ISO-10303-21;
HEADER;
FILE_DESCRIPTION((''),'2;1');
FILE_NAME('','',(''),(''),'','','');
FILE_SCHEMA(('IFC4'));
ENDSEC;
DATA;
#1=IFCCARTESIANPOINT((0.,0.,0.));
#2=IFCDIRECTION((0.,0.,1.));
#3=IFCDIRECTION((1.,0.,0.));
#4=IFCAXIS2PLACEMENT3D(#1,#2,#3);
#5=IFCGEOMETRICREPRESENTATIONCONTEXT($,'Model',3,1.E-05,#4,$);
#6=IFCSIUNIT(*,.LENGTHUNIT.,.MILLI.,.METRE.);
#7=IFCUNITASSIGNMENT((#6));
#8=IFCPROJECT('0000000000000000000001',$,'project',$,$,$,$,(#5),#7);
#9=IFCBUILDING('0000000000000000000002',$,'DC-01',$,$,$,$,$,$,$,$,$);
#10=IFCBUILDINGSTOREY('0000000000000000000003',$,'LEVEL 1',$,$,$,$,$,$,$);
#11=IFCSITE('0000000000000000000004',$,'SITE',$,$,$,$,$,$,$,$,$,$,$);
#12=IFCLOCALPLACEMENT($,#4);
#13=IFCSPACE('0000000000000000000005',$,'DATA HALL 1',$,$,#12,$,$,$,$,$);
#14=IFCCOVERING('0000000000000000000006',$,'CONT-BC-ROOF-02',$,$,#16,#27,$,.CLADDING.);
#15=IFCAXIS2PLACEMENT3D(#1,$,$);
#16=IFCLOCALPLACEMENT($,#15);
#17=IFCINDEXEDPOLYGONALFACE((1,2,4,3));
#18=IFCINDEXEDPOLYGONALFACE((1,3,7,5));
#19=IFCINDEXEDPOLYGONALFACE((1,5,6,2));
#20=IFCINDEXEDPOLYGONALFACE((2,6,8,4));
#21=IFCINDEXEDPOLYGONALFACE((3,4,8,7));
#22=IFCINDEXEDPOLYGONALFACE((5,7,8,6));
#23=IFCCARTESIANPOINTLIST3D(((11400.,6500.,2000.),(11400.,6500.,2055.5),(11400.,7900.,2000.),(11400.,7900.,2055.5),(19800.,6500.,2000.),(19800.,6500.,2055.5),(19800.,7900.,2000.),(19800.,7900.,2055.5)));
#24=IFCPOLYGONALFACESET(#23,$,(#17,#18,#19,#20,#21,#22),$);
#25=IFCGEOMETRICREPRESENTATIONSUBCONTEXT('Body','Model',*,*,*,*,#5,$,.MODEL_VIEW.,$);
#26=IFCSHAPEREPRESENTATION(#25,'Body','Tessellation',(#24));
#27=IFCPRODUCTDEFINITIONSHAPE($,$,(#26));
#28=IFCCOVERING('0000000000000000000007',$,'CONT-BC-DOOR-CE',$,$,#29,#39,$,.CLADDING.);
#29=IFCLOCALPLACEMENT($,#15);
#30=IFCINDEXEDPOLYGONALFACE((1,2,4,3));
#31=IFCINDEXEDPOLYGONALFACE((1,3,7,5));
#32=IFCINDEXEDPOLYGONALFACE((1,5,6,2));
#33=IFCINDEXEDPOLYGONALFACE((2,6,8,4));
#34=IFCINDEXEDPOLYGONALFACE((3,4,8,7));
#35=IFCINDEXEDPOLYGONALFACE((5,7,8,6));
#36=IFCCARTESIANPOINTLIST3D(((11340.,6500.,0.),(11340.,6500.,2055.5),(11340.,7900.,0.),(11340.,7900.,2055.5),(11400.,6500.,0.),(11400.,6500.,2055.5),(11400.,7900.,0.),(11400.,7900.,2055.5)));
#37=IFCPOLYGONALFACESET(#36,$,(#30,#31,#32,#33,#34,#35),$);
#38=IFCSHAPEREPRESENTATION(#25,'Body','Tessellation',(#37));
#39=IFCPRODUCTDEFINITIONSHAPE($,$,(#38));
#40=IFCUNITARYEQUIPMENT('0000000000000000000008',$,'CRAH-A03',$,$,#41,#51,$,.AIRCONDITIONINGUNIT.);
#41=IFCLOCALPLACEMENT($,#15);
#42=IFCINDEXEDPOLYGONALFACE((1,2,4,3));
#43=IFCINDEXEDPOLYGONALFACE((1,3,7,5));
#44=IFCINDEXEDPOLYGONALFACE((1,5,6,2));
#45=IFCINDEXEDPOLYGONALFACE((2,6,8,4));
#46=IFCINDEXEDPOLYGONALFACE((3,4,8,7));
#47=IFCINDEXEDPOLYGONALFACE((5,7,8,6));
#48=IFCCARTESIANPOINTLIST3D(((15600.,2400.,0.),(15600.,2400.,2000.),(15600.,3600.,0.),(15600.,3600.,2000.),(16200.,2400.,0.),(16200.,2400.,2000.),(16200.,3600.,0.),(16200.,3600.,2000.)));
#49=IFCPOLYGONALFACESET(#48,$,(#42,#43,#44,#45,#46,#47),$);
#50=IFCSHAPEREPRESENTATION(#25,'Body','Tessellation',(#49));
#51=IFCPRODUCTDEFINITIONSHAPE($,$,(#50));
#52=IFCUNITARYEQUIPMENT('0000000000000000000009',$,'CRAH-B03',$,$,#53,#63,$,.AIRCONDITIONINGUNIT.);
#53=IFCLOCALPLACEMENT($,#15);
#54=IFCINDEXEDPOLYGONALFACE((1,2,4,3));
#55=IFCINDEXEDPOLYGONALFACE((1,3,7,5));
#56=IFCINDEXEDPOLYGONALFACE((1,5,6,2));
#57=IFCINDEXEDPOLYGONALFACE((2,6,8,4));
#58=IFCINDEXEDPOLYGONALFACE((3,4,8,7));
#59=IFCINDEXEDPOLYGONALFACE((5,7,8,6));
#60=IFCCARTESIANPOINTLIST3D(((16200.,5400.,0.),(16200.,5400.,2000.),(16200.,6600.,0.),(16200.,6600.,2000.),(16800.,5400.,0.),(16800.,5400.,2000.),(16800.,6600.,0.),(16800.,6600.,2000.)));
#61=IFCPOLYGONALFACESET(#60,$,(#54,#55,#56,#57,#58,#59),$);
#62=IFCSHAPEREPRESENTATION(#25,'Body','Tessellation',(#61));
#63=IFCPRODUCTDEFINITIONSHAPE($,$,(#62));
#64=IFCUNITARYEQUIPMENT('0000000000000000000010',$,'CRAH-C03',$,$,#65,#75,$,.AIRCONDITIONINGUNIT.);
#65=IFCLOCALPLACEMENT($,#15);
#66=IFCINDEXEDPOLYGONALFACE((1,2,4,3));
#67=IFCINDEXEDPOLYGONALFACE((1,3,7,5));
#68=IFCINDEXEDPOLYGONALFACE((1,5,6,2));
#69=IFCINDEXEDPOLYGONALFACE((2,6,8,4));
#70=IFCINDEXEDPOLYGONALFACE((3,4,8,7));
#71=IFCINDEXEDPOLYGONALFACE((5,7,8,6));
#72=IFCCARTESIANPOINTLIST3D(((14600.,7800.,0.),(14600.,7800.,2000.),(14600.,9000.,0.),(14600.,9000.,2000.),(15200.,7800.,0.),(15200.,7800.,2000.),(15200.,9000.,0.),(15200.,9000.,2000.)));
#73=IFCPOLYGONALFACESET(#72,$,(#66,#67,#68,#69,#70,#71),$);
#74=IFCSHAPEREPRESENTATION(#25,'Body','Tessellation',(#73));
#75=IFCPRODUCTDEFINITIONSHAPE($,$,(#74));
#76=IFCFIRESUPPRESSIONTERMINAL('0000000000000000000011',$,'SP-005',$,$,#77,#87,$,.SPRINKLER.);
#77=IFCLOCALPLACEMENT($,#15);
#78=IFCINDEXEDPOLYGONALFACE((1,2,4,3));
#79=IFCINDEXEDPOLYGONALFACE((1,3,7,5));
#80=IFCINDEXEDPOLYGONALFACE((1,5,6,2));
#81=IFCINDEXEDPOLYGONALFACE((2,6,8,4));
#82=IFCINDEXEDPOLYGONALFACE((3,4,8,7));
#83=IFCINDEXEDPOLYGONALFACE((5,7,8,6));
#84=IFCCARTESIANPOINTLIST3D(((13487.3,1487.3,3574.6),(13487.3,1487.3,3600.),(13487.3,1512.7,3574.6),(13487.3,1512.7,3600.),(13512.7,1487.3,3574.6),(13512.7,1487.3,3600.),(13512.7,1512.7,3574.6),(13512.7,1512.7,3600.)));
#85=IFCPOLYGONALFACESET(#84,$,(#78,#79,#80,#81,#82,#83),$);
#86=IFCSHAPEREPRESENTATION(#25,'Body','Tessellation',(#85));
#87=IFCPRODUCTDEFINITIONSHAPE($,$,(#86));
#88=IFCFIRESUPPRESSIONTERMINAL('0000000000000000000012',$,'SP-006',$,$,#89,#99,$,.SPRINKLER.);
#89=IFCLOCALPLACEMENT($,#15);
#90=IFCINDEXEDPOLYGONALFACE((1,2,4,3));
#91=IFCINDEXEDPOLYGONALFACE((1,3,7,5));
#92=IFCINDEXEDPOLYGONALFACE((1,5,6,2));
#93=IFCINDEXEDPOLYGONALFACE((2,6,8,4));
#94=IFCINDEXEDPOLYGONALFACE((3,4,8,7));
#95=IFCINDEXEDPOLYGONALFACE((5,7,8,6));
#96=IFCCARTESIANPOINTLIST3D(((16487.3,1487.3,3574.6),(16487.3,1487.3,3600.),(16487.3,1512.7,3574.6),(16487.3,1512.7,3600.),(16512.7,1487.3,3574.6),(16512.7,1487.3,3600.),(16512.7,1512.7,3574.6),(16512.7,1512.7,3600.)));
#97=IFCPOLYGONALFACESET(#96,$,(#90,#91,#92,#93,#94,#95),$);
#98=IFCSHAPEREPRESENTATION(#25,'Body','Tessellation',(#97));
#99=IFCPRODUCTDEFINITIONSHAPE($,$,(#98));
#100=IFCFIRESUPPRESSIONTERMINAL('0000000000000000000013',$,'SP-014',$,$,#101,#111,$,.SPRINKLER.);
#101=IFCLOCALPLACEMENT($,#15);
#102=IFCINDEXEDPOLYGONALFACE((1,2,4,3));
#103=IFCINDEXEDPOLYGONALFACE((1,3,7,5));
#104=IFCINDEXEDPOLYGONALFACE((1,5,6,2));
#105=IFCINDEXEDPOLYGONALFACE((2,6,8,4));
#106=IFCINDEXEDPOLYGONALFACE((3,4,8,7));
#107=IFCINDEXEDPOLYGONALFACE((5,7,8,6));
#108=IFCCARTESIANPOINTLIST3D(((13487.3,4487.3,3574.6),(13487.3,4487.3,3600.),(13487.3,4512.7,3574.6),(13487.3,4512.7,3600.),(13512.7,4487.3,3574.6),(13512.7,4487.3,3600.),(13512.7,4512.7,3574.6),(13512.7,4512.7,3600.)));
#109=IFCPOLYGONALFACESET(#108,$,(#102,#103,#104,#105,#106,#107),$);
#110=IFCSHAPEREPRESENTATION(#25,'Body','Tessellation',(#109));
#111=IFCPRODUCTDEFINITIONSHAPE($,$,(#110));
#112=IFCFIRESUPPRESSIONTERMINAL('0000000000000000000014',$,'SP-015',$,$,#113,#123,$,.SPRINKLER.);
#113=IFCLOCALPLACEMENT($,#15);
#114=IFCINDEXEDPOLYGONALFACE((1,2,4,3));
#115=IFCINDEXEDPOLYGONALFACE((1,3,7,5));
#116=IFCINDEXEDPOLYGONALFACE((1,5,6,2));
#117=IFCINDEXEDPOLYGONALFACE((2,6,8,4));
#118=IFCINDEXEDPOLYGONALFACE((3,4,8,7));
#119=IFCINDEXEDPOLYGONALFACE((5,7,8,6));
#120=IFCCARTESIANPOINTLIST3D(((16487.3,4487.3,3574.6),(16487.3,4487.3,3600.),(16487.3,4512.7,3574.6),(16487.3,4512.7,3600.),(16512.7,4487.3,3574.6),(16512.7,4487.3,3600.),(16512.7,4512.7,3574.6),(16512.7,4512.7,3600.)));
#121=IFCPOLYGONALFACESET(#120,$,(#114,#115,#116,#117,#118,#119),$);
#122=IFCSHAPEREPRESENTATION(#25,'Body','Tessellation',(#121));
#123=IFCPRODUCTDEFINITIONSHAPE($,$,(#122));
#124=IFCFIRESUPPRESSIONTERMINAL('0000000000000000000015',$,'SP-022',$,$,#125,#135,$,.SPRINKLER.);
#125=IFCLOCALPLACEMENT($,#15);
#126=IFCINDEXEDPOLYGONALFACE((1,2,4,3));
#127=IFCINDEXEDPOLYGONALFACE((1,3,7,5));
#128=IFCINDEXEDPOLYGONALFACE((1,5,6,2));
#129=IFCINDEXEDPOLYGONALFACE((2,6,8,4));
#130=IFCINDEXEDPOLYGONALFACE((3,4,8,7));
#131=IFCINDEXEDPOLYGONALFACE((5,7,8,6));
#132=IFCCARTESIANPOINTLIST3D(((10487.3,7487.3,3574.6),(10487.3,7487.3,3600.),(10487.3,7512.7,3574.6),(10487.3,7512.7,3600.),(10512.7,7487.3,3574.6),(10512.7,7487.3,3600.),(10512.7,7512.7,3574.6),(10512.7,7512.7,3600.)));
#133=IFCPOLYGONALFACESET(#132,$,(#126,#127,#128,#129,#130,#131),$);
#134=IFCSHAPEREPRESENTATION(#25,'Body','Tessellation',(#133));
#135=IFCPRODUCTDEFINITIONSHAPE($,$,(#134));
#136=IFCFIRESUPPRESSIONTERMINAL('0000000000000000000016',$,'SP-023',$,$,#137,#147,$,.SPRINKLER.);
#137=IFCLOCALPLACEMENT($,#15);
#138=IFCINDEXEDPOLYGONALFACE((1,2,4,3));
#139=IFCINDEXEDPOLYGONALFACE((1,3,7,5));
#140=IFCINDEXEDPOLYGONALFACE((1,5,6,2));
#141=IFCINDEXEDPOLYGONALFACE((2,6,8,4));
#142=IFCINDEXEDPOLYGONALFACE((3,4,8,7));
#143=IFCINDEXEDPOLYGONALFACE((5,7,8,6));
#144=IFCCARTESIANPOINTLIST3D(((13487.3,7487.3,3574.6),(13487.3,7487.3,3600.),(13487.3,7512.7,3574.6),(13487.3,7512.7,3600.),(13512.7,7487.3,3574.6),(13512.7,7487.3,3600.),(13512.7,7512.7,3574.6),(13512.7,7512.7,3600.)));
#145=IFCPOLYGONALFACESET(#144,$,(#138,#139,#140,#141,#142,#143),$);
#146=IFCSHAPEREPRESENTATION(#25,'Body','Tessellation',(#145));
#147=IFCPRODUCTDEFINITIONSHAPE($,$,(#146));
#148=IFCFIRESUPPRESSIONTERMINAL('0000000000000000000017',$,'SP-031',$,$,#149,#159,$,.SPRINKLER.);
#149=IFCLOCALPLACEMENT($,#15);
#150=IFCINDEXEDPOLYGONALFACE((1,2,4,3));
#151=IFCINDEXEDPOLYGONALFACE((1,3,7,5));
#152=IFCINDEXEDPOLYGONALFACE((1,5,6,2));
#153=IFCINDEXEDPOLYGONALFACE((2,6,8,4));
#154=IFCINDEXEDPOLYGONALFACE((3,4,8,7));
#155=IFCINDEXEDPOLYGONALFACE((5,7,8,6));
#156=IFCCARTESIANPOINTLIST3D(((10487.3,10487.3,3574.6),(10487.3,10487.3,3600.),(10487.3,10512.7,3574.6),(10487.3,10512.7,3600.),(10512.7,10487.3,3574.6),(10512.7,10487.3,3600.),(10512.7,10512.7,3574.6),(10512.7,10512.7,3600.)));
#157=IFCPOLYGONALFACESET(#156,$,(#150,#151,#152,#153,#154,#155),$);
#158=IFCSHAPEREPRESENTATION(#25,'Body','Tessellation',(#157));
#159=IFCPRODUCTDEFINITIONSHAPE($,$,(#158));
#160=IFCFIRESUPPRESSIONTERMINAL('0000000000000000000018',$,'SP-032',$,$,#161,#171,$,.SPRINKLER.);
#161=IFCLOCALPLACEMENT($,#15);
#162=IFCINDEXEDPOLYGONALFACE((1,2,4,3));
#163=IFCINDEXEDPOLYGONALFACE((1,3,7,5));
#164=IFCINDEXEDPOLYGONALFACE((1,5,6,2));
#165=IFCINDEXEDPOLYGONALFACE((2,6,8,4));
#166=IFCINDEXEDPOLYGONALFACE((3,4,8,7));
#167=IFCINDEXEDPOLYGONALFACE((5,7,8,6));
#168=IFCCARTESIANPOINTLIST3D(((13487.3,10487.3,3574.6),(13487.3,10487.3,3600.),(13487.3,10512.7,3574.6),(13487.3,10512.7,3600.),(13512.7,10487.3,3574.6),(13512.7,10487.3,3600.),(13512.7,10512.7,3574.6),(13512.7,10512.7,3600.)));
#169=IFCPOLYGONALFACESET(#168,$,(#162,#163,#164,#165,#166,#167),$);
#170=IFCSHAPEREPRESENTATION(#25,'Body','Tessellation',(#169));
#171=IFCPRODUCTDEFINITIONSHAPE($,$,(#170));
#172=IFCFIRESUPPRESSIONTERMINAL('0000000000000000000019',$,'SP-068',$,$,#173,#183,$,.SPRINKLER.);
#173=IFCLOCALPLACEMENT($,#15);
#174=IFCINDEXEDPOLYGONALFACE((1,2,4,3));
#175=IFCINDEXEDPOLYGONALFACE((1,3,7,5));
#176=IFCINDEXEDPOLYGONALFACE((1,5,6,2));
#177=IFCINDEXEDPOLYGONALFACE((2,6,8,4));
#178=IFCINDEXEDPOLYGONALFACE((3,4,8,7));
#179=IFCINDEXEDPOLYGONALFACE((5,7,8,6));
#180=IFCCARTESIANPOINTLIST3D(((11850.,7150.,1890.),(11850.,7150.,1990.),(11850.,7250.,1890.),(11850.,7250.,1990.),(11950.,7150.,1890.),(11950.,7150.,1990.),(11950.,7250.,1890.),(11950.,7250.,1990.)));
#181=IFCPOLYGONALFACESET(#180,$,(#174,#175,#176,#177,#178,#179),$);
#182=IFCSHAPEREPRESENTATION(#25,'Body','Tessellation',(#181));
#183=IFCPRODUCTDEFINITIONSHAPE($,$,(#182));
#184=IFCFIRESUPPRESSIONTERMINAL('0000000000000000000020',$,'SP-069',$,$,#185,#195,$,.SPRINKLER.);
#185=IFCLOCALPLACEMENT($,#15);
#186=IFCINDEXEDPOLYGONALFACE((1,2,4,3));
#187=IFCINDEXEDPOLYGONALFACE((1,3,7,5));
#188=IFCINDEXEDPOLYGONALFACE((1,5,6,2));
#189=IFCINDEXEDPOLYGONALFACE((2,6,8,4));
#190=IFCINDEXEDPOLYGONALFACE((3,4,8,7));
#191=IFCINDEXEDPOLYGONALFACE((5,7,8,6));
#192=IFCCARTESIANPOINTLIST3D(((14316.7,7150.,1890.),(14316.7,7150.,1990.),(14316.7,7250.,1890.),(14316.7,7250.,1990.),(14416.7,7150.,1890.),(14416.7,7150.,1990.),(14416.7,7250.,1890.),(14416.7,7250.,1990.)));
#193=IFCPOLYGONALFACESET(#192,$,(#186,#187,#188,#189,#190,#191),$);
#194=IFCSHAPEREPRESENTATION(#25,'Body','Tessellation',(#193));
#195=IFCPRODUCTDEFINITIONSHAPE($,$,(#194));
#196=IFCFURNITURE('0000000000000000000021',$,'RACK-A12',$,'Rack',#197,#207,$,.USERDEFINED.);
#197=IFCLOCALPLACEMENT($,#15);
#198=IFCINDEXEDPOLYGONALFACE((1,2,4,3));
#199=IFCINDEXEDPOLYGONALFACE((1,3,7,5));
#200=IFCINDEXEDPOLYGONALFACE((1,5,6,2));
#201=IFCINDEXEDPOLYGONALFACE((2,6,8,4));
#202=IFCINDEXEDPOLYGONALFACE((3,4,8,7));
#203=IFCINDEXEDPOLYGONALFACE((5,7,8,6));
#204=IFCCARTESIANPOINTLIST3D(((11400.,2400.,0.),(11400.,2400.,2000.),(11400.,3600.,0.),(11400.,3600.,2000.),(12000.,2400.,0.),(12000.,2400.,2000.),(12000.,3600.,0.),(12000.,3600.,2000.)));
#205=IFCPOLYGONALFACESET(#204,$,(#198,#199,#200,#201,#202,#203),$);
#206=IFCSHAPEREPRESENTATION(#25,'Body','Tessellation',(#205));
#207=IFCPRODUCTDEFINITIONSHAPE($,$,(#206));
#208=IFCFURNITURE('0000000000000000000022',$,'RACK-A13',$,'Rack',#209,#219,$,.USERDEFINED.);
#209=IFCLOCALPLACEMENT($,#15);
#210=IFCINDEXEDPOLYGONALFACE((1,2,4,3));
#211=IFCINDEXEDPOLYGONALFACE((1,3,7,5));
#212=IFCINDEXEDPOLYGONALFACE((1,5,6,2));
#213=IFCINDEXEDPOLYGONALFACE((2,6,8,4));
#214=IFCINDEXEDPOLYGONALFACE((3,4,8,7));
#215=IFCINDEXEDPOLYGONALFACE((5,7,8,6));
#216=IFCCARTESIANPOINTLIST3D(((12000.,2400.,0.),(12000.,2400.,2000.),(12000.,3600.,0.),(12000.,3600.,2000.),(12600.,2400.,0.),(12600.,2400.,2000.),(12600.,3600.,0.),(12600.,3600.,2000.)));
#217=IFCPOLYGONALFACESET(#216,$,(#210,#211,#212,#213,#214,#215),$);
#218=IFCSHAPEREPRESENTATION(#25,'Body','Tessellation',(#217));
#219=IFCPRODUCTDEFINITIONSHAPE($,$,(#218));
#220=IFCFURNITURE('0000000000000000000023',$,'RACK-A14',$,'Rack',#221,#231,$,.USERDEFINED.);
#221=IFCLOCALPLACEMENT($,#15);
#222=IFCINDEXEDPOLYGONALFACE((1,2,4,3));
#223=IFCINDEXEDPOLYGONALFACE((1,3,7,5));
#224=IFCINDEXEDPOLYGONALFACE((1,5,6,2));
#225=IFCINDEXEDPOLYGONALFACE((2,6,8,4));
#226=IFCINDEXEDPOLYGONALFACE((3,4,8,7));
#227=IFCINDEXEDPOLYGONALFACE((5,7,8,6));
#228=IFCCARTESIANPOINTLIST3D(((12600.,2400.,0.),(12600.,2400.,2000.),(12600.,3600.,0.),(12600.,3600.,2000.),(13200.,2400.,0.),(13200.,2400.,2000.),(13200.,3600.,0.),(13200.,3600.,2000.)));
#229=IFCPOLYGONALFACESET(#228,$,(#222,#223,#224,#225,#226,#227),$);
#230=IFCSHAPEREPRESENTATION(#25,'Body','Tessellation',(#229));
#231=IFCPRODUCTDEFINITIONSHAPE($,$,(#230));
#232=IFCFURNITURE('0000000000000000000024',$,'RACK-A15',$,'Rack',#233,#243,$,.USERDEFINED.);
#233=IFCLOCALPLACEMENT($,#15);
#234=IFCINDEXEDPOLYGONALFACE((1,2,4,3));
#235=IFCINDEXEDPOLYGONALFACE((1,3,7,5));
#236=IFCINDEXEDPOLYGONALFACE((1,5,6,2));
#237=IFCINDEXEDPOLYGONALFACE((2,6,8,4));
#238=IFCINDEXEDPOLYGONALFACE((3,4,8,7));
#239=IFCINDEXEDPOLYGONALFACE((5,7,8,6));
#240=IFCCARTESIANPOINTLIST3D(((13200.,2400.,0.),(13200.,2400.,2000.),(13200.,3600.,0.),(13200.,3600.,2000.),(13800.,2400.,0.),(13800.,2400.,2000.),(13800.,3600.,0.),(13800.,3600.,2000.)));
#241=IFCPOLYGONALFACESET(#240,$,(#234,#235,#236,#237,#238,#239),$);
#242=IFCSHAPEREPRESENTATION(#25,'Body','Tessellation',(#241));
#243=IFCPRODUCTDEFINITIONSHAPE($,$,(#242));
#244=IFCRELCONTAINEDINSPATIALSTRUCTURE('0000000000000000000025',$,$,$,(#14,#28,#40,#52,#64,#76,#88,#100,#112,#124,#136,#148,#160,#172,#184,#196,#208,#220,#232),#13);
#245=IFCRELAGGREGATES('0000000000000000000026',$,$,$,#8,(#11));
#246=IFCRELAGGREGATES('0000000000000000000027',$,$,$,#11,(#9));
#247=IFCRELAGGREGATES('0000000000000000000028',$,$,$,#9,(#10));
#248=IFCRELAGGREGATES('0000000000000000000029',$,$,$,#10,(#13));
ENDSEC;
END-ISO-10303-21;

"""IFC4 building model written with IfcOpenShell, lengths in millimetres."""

from ifc_helpers import new_model, si_unit, frame, origin, origin_with_axes, place, context, subcontext, project, spatial, polyline, outline, extrude, element, save


model = new_model("IFC4")

# Units and contexts
model_context = context("Model", 3, precision=1e-05, world=origin_with_axes())
body_context = subcontext(model_context, "Body", "Model", "MODEL_VIEW")
ifc_project = project(units=[si_unit("LENGTHUNIT", "METRE", prefix="MILLI")], contexts=[model_context])

# Site, building, storey, space
site = spatial("IfcSite", under=ifc_project, Name="SITE")
building = spatial("IfcBuilding", under=site, Name="DC-01")
storey = spatial("IfcBuildingStorey", under=building, Name="LEVEL 1")
space_placement = place(None, origin_with_axes())
space = spatial("IfcSpace", under=storey, at=space_placement, Name="DATA HALL 1")

# Coverings
covering_1_placement = place(space_placement, frame((11400.0, 6500.0, 2000.0), z_axis=(0.0, 0.0, 1.0), x_axis=(1.0, 0.0, 0.0)))
element("IfcCovering", 1, at=covering_1_placement, inside=space, Name="CONT-BC-ROOF-02", PredefinedType="CLADDING", context=body_context, shape_type="SweptSolid", body=[
    extrude(outline(polyline([(0.0, 0.0), (8400.0, 0.0), (8400.0, 1400.0), (0.0, 1400.0), (0.0, 0.0)])), origin(), (0.0, 0.0, 1.0), 55.5),
])
covering_2_placement = place(space_placement, frame((11340.0, 6500.0, 0.0), z_axis=(0.0, 0.0, 1.0), x_axis=(1.0, 0.0, 0.0)))
element("IfcCovering", 2, at=covering_2_placement, inside=space, Name="CONT-BC-DOOR-CE", PredefinedType="CLADDING", context=body_context, shape_type="SweptSolid", body=[
    extrude(outline(polyline([(0.0, 0.0), (60.0, 0.0), (60.0, 1400.0), (0.0, 1400.0), (0.0, 0.0)])), origin(), (0.0, 0.0, 1.0), 2055.5),
])

# Unitary equipment
for number, where, z_axis, x_axis, name in (
    (3, (16200.0, 3600.0, 0.0), (0.0, 0.0, 1.0), (-1.0, 0.0, 0.0), "CRAH-A03"),
    (4, (16200.0, 5400.0, 0.0), (0.0, 0.0, 1.0), (1.0, 0.0, 0.0), "CRAH-B03"),
    (5, (15200.0, 9000.0, 0.0), (0.0, 0.0, 1.0), (-1.0, 0.0, 0.0), "CRAH-C03"),
):
    element("IfcUnitaryEquipment", number, at=place(space_placement, frame(where, z_axis=z_axis, x_axis=x_axis)), inside=space, Name=name, PredefinedType="AIRCONDITIONINGUNIT", context=body_context, shape_type="SweptSolid", body=[
        extrude(outline(polyline([(0.0, 0.0), (600.0, 0.0), (600.0, 1200.0), (0.0, 1200.0), (0.0, 0.0)])), origin(), (0.0, 0.0, 1.0), 2000.0),
    ])

# Fire suppression terminals
for number, where, z_axis, x_axis, name in (
    (6, (13487.3, 1487.3, 3574.6), (0.0, 0.0, 1.0), (1.0, 0.0, 0.0), "SP-005"),
    (7, (16487.3, 1487.3, 3574.6), (0.0, 0.0, 1.0), (1.0, 0.0, 0.0), "SP-006"),
    (8, (13487.3, 4487.3, 3574.6), (0.0, 0.0, 1.0), (1.0, 0.0, 0.0), "SP-014"),
    (9, (16487.3, 4487.3, 3574.6), (0.0, 0.0, 1.0), (1.0, 0.0, 0.0), "SP-015"),
    (10, (10487.3, 7487.3, 3574.6), (0.0, 0.0, 1.0), (1.0, 0.0, 0.0), "SP-022"),
    (11, (13487.3, 7487.3, 3574.6), (0.0, 0.0, 1.0), (1.0, 0.0, 0.0), "SP-023"),
    (12, (10487.3, 10487.3, 3574.6), (0.0, 0.0, 1.0), (1.0, 0.0, 0.0), "SP-031"),
    (13, (13487.3, 10487.3, 3574.6), (0.0, 0.0, 1.0), (1.0, 0.0, 0.0), "SP-032"),
):
    element("IfcFireSuppressionTerminal", number, at=place(space_placement, frame(where, z_axis=z_axis, x_axis=x_axis)), inside=space, Name=name, PredefinedType="SPRINKLER", context=body_context, shape_type="SweptSolid", body=[
        extrude(outline(polyline([(0.0, 0.0), (25.4, 0.0), (25.4, 25.4), (0.0, 25.4), (0.0, 0.0)])), origin(), (0.0, 0.0, 1.0), 25.4),
    ])
for number, where, z_axis, x_axis, name in (
    (14, (11850.0, 7150.0, 1890.0), (0.0, 0.0, 1.0), (1.0, 0.0, 0.0), "SP-068"),
    (15, (14316.7, 7150.0, 1890.0), (0.0, 0.0, 1.0), (1.0, 0.0, 0.0), "SP-069"),
):
    element("IfcFireSuppressionTerminal", number, at=place(space_placement, frame(where, z_axis=z_axis, x_axis=x_axis)), inside=space, Name=name, PredefinedType="SPRINKLER", context=body_context, shape_type="SweptSolid", body=[
        extrude(outline(polyline([(0.0, 0.0), (100.0, 0.0), (100.0, 100.0), (0.0, 100.0), (0.0, 0.0)])), origin(), (0.0, 0.0, 1.0), 100.0),
    ])

# Furniture
for number, where, z_axis, x_axis, name in (
    (16, (12000.0, 3600.0, 0.0), (0.0, 0.0, 1.0), (-1.0, 0.0, 0.0), "RACK-A12"),
    (17, (12600.0, 3600.0, 0.0), (0.0, 0.0, 1.0), (-1.0, 0.0, 0.0), "RACK-A13"),
    (18, (13200.0, 3600.0, 0.0), (0.0, 0.0, 1.0), (-1.0, 0.0, 0.0), "RACK-A14"),
    (19, (13800.0, 3600.0, 0.0), (0.0, 0.0, 1.0), (-1.0, 0.0, 0.0), "RACK-A15"),
):
    element("IfcFurniture", number, at=place(space_placement, frame(where, z_axis=z_axis, x_axis=x_axis)), inside=space, Name=name, ObjectType="Rack", PredefinedType="USERDEFINED", context=body_context, shape_type="SweptSolid", body=[
        extrude(outline(polyline([(0.0, 0.0), (600.0, 0.0), (600.0, 1200.0), (0.0, 1200.0), (0.0, 0.0)])), origin(), (0.0, 0.0, 1.0), 2000.0),
    ])

save(model, "model.ifc")
